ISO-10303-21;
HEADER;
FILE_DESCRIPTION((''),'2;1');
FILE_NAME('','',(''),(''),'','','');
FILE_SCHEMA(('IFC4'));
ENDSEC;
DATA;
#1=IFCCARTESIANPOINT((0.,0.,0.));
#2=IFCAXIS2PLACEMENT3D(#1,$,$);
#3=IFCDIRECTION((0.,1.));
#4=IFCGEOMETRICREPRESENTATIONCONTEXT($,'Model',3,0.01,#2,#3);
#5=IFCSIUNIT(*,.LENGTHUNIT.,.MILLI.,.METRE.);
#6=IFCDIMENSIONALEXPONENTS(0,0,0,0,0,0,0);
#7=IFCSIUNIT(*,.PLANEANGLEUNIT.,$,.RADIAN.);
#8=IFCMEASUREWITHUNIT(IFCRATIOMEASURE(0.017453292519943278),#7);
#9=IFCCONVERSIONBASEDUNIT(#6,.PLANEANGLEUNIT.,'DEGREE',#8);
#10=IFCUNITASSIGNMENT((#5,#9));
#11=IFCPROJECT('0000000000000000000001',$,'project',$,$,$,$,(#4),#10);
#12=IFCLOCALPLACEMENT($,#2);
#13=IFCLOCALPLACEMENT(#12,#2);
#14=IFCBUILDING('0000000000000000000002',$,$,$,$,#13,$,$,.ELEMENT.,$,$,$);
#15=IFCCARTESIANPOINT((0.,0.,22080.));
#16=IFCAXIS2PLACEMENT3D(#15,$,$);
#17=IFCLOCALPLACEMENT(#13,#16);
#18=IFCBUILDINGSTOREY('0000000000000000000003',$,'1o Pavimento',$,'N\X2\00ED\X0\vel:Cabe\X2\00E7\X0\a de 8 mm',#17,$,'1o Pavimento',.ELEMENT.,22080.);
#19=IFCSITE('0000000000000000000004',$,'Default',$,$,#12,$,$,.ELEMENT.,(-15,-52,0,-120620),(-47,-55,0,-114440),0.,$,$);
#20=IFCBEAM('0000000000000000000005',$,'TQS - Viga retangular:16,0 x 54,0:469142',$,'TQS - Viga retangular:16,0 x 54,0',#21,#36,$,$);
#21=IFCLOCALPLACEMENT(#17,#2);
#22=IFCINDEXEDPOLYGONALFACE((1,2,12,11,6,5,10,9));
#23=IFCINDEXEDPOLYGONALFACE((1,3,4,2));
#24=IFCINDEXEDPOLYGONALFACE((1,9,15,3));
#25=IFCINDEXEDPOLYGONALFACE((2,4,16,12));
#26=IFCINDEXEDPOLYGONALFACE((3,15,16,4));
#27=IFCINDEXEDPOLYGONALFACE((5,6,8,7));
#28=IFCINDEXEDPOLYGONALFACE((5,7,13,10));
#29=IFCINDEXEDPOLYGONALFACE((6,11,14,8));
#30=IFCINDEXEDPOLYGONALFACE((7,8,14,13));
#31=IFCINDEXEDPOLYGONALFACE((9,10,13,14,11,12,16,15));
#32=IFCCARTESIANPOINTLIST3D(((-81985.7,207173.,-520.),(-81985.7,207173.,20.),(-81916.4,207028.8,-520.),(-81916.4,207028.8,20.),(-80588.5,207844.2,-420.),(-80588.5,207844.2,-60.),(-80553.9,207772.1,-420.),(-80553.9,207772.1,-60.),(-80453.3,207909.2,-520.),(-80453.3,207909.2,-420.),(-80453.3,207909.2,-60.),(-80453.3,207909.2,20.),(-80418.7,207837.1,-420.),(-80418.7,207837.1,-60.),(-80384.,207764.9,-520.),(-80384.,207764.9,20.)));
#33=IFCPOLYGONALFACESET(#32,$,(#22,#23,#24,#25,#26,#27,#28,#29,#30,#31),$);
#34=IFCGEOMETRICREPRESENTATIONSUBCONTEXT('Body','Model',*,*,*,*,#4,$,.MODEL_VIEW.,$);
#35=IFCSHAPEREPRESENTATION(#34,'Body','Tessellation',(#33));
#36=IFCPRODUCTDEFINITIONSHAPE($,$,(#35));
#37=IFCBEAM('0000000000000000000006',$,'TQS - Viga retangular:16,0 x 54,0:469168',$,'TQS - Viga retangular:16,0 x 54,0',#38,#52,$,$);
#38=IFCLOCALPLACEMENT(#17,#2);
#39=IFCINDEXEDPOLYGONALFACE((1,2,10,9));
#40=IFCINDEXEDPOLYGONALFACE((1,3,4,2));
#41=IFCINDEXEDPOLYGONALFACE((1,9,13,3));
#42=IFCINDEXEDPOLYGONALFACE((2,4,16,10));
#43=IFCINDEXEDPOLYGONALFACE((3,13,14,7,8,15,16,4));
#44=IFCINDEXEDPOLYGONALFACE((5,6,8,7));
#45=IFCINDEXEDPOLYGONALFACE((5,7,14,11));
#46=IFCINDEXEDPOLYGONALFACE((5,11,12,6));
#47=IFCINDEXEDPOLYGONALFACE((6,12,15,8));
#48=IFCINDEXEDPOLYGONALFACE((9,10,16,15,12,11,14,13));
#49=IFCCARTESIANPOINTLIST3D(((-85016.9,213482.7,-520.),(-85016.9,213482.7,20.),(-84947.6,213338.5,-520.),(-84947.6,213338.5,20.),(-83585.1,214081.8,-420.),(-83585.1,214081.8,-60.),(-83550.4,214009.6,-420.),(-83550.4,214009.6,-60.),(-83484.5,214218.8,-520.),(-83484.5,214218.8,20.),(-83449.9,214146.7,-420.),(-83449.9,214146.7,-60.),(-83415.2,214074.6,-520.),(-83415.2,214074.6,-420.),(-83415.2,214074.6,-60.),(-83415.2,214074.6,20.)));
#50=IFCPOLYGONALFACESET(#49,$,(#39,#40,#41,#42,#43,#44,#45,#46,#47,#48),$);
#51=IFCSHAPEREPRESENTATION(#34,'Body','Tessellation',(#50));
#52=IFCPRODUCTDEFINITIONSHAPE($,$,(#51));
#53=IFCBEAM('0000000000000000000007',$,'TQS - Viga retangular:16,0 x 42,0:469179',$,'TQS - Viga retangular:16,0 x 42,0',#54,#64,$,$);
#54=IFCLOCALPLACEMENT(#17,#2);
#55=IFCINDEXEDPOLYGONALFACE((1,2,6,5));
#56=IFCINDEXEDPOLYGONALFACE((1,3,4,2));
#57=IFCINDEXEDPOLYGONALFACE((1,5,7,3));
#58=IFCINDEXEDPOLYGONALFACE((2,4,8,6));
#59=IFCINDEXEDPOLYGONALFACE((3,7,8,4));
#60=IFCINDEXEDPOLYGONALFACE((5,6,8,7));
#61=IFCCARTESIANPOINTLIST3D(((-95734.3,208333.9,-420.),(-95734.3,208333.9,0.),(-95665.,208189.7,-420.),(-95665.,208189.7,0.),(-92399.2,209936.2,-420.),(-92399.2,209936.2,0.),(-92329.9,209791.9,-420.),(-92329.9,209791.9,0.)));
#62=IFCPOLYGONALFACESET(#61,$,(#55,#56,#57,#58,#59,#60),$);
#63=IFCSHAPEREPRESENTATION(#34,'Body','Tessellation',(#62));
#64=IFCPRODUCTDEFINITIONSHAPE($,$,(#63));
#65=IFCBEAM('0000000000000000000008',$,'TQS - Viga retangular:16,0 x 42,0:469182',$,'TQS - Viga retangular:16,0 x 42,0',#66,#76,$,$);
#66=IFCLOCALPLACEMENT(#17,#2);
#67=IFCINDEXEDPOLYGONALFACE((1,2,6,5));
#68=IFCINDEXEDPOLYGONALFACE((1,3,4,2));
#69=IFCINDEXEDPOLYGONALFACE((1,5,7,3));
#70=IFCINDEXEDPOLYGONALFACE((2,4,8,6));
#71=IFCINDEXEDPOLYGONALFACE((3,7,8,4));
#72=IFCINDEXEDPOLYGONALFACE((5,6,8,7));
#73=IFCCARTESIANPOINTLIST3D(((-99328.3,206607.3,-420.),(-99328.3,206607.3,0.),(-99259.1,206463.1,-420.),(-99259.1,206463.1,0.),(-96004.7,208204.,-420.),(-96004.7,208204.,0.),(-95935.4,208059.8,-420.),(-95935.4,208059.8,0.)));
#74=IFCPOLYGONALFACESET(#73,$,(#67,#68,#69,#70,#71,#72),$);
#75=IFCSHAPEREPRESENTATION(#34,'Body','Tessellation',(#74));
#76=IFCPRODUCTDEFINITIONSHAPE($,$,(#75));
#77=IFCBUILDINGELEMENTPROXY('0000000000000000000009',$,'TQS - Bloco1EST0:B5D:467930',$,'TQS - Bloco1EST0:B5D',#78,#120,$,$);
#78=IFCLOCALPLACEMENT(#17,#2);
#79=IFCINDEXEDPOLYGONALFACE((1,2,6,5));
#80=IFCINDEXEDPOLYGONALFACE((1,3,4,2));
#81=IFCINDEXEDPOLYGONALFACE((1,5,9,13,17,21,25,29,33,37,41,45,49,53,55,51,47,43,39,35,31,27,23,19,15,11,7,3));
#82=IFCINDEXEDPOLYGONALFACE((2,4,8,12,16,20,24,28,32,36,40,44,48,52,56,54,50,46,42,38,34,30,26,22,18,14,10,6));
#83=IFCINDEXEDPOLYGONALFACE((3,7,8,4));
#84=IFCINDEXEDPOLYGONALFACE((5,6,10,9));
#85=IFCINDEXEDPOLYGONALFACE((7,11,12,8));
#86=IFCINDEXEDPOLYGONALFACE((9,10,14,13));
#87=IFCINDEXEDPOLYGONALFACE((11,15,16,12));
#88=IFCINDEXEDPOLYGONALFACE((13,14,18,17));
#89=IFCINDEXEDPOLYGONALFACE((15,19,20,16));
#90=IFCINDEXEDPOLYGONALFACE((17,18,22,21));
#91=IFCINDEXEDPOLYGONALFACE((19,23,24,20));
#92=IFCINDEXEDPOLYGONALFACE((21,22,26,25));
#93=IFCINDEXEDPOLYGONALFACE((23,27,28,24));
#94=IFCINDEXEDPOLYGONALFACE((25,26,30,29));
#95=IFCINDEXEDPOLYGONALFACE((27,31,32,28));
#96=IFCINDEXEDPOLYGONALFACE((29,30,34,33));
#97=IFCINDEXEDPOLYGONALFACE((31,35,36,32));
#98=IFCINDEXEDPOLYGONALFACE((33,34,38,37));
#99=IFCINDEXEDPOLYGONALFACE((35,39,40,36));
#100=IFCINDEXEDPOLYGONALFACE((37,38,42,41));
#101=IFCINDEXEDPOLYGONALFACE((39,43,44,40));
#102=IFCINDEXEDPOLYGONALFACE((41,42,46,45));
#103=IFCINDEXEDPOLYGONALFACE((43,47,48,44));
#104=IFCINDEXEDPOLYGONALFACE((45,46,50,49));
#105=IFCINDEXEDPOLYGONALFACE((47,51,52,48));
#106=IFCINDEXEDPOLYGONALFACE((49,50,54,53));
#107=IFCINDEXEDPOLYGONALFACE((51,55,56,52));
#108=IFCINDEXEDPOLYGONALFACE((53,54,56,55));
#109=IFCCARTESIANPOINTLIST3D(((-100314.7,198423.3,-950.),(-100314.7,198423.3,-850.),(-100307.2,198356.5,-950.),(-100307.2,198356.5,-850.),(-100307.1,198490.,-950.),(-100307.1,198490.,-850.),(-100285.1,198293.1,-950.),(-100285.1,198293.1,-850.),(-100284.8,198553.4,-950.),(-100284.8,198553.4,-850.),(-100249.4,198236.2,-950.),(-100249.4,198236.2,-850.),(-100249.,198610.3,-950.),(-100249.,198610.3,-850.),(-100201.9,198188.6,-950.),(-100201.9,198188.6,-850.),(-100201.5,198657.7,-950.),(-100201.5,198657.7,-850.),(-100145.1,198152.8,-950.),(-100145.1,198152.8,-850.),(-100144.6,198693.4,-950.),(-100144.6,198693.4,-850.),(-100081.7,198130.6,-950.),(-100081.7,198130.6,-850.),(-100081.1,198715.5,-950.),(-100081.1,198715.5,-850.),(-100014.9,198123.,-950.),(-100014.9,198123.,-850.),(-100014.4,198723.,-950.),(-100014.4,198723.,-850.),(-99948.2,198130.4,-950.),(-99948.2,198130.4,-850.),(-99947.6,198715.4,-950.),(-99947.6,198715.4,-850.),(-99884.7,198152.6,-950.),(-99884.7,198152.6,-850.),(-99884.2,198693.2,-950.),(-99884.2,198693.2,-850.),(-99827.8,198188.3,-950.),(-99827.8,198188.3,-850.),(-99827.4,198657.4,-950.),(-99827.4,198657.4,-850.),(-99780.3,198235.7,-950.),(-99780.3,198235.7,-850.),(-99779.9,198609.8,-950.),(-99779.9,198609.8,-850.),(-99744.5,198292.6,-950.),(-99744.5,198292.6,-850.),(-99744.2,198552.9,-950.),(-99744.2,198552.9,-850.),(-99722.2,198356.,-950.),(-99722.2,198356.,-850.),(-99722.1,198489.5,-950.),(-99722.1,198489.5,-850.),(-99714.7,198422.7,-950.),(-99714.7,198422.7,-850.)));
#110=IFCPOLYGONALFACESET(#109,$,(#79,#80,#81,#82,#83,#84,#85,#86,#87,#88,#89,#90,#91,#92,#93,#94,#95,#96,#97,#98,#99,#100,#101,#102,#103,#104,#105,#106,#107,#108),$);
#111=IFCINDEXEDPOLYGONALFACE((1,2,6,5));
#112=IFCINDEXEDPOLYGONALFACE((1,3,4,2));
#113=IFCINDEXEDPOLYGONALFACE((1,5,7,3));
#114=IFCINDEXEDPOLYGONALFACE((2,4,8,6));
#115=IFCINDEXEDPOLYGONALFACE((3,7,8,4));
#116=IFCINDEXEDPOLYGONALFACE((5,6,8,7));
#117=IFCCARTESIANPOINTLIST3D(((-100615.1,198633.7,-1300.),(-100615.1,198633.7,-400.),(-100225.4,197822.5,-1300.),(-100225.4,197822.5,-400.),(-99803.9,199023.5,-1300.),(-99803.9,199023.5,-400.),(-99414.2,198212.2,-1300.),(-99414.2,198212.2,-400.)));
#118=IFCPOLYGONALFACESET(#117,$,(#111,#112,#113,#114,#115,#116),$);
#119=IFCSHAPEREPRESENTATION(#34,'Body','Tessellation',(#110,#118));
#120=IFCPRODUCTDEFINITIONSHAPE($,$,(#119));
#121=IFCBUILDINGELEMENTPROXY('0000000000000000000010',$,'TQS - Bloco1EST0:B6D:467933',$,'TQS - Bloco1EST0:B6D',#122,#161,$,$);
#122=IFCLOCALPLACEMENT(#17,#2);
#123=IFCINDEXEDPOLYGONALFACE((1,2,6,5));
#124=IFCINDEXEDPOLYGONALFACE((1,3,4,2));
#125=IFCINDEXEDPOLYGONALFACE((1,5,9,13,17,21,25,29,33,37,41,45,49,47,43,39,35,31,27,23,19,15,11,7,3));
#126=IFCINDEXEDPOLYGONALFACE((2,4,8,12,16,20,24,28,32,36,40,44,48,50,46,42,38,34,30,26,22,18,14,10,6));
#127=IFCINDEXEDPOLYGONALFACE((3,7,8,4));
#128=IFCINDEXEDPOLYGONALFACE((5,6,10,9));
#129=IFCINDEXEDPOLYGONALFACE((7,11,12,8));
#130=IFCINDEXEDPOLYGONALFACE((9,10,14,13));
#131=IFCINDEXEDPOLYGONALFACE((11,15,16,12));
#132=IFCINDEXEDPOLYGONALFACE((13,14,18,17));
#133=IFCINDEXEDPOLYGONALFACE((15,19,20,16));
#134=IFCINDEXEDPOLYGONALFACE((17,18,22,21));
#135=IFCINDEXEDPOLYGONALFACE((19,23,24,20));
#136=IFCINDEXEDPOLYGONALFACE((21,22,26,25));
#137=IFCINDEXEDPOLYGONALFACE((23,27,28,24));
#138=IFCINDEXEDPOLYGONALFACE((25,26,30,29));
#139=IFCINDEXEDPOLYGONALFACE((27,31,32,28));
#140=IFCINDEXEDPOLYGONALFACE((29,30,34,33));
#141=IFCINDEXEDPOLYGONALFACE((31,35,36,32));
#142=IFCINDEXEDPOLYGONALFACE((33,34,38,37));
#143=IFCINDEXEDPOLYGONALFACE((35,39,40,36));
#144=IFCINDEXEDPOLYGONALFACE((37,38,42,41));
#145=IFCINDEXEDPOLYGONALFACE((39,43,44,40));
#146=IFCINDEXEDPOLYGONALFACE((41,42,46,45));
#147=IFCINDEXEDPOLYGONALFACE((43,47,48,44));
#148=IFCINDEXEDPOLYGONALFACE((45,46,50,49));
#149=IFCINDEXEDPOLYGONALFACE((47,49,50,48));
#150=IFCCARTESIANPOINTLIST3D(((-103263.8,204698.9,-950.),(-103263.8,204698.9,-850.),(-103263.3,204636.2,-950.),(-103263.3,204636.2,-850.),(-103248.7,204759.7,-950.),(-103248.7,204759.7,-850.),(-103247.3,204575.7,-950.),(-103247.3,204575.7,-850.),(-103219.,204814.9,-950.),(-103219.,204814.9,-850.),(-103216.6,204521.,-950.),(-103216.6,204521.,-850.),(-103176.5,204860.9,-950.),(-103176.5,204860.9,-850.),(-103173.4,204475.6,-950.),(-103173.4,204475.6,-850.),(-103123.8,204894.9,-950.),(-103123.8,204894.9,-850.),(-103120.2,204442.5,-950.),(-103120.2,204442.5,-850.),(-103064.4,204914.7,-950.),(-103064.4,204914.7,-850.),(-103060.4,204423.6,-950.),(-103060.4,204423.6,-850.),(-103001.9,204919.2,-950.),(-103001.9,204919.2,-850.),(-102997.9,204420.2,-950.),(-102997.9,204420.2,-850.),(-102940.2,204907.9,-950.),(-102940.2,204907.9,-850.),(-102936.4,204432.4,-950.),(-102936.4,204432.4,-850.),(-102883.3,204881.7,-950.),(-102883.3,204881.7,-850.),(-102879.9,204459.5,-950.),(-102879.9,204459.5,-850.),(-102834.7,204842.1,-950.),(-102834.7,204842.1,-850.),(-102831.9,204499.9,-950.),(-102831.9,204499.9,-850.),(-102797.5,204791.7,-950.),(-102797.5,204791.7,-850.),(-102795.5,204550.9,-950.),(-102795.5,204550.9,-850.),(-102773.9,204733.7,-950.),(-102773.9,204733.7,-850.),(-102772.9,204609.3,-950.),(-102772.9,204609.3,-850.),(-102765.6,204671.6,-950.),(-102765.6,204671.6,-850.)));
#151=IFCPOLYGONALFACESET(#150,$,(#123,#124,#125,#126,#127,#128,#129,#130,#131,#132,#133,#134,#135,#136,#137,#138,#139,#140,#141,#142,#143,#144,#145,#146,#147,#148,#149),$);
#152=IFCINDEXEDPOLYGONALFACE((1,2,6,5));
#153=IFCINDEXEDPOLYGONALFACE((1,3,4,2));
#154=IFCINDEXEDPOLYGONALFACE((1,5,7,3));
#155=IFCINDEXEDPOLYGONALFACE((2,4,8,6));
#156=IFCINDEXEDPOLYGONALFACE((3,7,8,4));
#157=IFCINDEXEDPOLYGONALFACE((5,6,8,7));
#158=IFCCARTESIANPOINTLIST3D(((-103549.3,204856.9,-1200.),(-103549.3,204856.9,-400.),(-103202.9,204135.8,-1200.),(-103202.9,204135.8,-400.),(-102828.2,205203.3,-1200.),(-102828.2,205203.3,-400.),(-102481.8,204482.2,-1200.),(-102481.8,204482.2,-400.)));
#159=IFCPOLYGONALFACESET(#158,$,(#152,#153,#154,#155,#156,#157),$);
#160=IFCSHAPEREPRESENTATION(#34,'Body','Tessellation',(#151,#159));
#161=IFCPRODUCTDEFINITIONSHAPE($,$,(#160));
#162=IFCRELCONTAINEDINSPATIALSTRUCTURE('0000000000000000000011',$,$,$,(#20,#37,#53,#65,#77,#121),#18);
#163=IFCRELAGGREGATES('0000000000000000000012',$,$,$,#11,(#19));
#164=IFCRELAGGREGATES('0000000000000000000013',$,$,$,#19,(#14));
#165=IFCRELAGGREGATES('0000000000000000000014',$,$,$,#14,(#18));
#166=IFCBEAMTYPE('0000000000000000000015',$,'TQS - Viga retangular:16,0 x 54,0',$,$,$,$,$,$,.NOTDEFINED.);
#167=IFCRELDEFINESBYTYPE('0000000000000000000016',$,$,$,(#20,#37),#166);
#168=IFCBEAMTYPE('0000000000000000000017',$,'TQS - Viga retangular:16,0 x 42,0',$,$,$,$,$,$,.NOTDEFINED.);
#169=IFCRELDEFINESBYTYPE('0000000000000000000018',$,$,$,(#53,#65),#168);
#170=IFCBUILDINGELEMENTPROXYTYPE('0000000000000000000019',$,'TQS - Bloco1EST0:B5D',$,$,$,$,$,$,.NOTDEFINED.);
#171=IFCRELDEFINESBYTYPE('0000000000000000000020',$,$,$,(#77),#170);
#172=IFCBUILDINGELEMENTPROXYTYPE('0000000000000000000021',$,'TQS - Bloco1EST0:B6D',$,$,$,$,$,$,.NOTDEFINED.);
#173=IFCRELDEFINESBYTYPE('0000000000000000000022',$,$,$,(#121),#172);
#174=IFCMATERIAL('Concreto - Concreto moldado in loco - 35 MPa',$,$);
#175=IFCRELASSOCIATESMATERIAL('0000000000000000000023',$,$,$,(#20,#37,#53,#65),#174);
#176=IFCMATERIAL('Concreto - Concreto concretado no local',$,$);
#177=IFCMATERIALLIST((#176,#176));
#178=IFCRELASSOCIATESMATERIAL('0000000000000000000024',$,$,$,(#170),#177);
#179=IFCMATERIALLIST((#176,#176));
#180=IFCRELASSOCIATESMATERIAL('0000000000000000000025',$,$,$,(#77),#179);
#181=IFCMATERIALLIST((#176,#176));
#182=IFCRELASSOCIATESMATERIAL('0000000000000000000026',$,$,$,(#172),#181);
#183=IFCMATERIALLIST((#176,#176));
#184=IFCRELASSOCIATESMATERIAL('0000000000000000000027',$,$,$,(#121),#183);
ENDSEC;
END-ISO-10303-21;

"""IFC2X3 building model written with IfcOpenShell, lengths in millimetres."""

from ifc_helpers import new_model, entity, si_unit, converted_unit, direction, frame, frame_2d, origin, origin_2d_with_axis, place, context, subcontext, project, spatial, polyline, rectangle, circle, extrude, boolean, clip, bounded_halfspace, source, transform, mapped, material, material_list, type_object, type_shapes, element, save


model = new_model("IFC2X3")

# Units and contexts
model_context = context("Model", 3, precision=0.01, world=origin(), true_north=direction((0.0, 1.0)))
body_context = subcontext(model_context, "Body", "Model", "MODEL_VIEW")
ifc_project = project(units=[si_unit("LENGTHUNIT", "METRE", prefix="MILLI"), converted_unit("PLANEANGLEUNIT", "DEGREE", entity("IfcRatioMeasure", 0.017453292519943278), si_unit("PLANEANGLEUNIT", "RADIAN"), dimensions=[0, 0, 0, 0, 0, 0, 0])], contexts=[model_context])

# Site, building, storey
site_placement = place(None, origin())
site = spatial("IfcSite", under=ifc_project, at=site_placement, Name="Default", CompositionType="ELEMENT", RefLatitude=(-15, -52, 0, -120620), RefLongitude=(-47, -55, 0, -114440), RefElevation=0.0)
building_placement = place(site_placement, origin())
building = spatial("IfcBuilding", under=site, at=building_placement, CompositionType="ELEMENT")
storey_placement = place(building_placement, frame((0.0, 0.0, 22080.0)))
storey = spatial("IfcBuildingStorey", under=building, at=storey_placement, Name="1o Pavimento", ObjectType="Nível:Cabeça de 8 mm", LongName="1o Pavimento", CompositionType="ELEMENT", Elevation=22080.0)

# Beams
ifc_material_1 = material(Name="Concreto - Concreto moldado in loco - 35 MPa")
beam_type_1 = type_object("IfcBeamType", Name="TQS - Viga retangular:16,0 x 54,0", PredefinedType="NOTDEFINED")
beam_1_placement = place(storey_placement, frame((-80418.7, 207837.1, 20.0), z_axis=(0.0, 0.0, 1.0), x_axis=(-0.90138, -0.43303, 0.0)))
element("IfcBeam", 1, at=beam_1_placement, inside=storey, type_object=beam_type_1, material=ifc_material_1, Name="TQS - Viga retangular:16,0 x 54,0:469142", ObjectType="TQS - Viga retangular:16,0 x 54,0", context=body_context, shape_type="SweptSolid", body=[
    boolean("DIFFERENCE", clip(extrude(rectangle(XDim=540.0, YDim=160.0, at=frame_2d((0.0, 0.0), x_axis=(0.0, 1.0))), frame((0.0, 0.0, -270.0), z_axis=(1.0, 0.0, 0.0), x_axis=(0.0, 1.0, 0.0)), (0.0, 0.0, 1.0), 1700.0), bounded_halfspace(frame((150.0, -7000.0, -440.0), z_axis=(-1.0, 0.0, 0.0), x_axis=(0.0, 1.0, 0.0)), False, frame((0.0, 0.0, -270.0), z_axis=(1.0, 0.0, 0.0), x_axis=(0.0, 1.0, 0.0)), polyline([(0.0, 190.0), (0.0, -170.0), (-80.0, -170.0), (-80.0, 90.0), (-80.0, 190.0), (0.0, 190.0)]))), extrude(rectangle(XDim=360.0, YDim=80.0, at=frame_2d((0.0, 0.0), x_axis=(0.0, 1.0))), frame((150.0, -40.0, -260.0), z_axis=(1.0, 0.0, 0.0), x_axis=(0.0, 1.0, 0.0)), (0.0, 0.0, -1.0), 150.0)),
])
beam_2_placement = place(storey_placement, frame((-83449.9, 214146.7, 20.0), z_axis=(0.0, 0.0, 1.0), x_axis=(-0.90138, -0.43303, 0.0)))
element("IfcBeam", 2, at=beam_2_placement, inside=storey, type_object=beam_type_1, material=ifc_material_1, Name="TQS - Viga retangular:16,0 x 54,0:469168", ObjectType="TQS - Viga retangular:16,0 x 54,0", context=body_context, shape_type="SweptSolid", body=[
    boolean("DIFFERENCE", clip(extrude(rectangle(XDim=540.0, YDim=160.0, at=frame_2d((0.0, 0.0), x_axis=(1.0, 0.0))), frame((0.0, 0.0, -270.0), z_axis=(1.0, 0.0, 0.0), x_axis=(0.0, 0.0, -1.0)), (0.0, 0.0, 1.0), 1700.0), bounded_halfspace(frame((150.0, 0.0, -440.0), z_axis=(-1.0, 0.0, 0.0), x_axis=(0.0, 1.0, 0.0)), False, frame((0.0, 0.0, -270.0), z_axis=(1.0, 0.0, 0.0), x_axis=(0.0, 0.0, -1.0)), polyline([(170.0, 0.0), (-190.0, 0.0), (-190.0, 80.0), (-90.0, 80.0), (170.0, 80.0), (170.0, 0.0)]))), extrude(rectangle(XDim=360.0, YDim=80.0, at=frame_2d((0.0, 0.0), x_axis=(0.0, 1.0))), frame((0.0, 40.0, -260.0), z_axis=(-1.0, 0.0, 0.0), x_axis=(0.0, -1.0, 0.0)), (0.0, 0.0, -1.0), 150.0)),
])
beam_type_2 = type_object("IfcBeamType", Name="TQS - Viga retangular:16,0 x 42,0", PredefinedType="NOTDEFINED")
beam_3_placement = place(storey_placement, frame((-92292.4, 209898.7, 0.0), z_axis=(0.0, 0.0, 1.0), x_axis=(-0.90138, -0.43303, 0.0)))
element("IfcBeam", 3, at=beam_3_placement, inside=storey, type_object=beam_type_2, material=ifc_material_1, Name="TQS - Viga retangular:16,0 x 42,0:469179", ObjectType="TQS - Viga retangular:16,0 x 42,0", context=body_context, shape_type="SweptSolid", body=[
    extrude(rectangle(XDim=420.0, YDim=160.0, at=frame_2d((0.0, 0.0), x_axis=(1.0, 0.0))), frame((80.0, 0.0, -210.0), z_axis=(1.0, 0.0, 0.0), x_axis=(0.0, 0.0, -1.0)), (0.0, 0.0, 1.0), 3700.0),
])
beam_4_placement = place(storey_placement, frame((-95897.9, 208166.6, 0.0), z_axis=(0.0, 0.0, 1.0), x_axis=(-0.90138, -0.43303, 0.0)))
element("IfcBeam", 4, at=beam_4_placement, inside=storey, type_object=beam_type_2, material=ifc_material_1, Name="TQS - Viga retangular:16,0 x 42,0:469182", ObjectType="TQS - Viga retangular:16,0 x 42,0", context=body_context, shape_type="SweptSolid", body=[
    extrude(rectangle(XDim=420.0, YDim=160.0, at=frame_2d((0.0, 0.0), x_axis=(1.0, 0.0))), frame((80.0, 0.0, -210.0), z_axis=(1.0, 0.0, 0.0), x_axis=(0.0, 0.0, -1.0)), (0.0, 0.0, 1.0), 3687.3),
])

# Building element proxies
ifc_material_2 = material(Name="Concreto - Concreto concretado no local")
ifc_material_list_1 = material_list([ifc_material_2, ifc_material_2])
ifc_material_list_2 = material_list([ifc_material_2, ifc_material_2])
building_element_proxy_type_1 = type_object("IfcBuildingElementProxyType", Name="TQS - Bloco1EST0:B5D", PredefinedType="NOTDEFINED", material=ifc_material_list_2)
shared_shape_1 = source(origin(), body_context, "Body", "SweptSolid", [
    extrude(circle(Radius=300.0, at=frame_2d((0.0, 0.0), x_axis=(1.0, 0.0))), frame((0.0, 0.0, -550.0)), (0.0, 0.0, 1.0), 100.0),
    extrude(rectangle(XDim=900.0, YDim=900.0, at=origin_2d_with_axis()), frame((0.0, 0.0, -900.0), z_axis=(0.0, 0.0, 1.0), x_axis=(-1.0, 0.0, 0.0)), (0.0, 0.0, 1.0), 900.0),
])
type_shapes(building_element_proxy_type_1, [shared_shape_1])
proxy_1_placement = place(storey_placement, frame((-100014.7, 198423.0, -400.0), z_axis=(0.0, 0.0, 1.0), x_axis=(-0.43303, 0.90138, 0.0)))
element("IfcBuildingElementProxy", 5, at=proxy_1_placement, inside=storey, type_object=building_element_proxy_type_1, material=ifc_material_list_1, Name="TQS - Bloco1EST0:B5D:467930", ObjectType="TQS - Bloco1EST0:B5D", context=body_context, shape_type="MappedRepresentation", body=[
    mapped(shared_shape_1, transform((0.0, 0.0, 0.0), scale=1.0)),
])
ifc_material_list_3 = material_list([ifc_material_2, ifc_material_2])
ifc_material_list_4 = material_list([ifc_material_2, ifc_material_2])
building_element_proxy_type_2 = type_object("IfcBuildingElementProxyType", Name="TQS - Bloco1EST0:B6D", PredefinedType="NOTDEFINED", material=ifc_material_list_4)
shared_shape_2 = source(origin(), body_context, "Body", "SweptSolid", [
    extrude(circle(Radius=250.0, at=frame_2d((0.0, 0.0), x_axis=(1.0, 0.0))), frame((0.0, 0.0, -550.0)), (0.0, 0.0, 1.0), 100.0),
    extrude(rectangle(XDim=800.0, YDim=800.0, at=origin_2d_with_axis()), frame((0.0, 0.0, -800.0), z_axis=(0.0, 0.0, 1.0), x_axis=(-1.0, 0.0, 0.0)), (0.0, 0.0, 1.0), 800.0),
])
type_shapes(building_element_proxy_type_2, [shared_shape_2])
proxy_2_placement = place(storey_placement, frame((-103015.6, 204669.5, -400.0), z_axis=(0.0, 0.0, 1.0), x_axis=(-0.43303, 0.90138, 0.0)))
element("IfcBuildingElementProxy", 6, at=proxy_2_placement, inside=storey, type_object=building_element_proxy_type_2, material=ifc_material_list_3, Name="TQS - Bloco1EST0:B6D:467933", ObjectType="TQS - Bloco1EST0:B6D", context=body_context, shape_type="MappedRepresentation", body=[
    mapped(shared_shape_2, transform((0.0, 0.0, 0.0), scale=1.0)),
])

save(model, "model.ifc")
